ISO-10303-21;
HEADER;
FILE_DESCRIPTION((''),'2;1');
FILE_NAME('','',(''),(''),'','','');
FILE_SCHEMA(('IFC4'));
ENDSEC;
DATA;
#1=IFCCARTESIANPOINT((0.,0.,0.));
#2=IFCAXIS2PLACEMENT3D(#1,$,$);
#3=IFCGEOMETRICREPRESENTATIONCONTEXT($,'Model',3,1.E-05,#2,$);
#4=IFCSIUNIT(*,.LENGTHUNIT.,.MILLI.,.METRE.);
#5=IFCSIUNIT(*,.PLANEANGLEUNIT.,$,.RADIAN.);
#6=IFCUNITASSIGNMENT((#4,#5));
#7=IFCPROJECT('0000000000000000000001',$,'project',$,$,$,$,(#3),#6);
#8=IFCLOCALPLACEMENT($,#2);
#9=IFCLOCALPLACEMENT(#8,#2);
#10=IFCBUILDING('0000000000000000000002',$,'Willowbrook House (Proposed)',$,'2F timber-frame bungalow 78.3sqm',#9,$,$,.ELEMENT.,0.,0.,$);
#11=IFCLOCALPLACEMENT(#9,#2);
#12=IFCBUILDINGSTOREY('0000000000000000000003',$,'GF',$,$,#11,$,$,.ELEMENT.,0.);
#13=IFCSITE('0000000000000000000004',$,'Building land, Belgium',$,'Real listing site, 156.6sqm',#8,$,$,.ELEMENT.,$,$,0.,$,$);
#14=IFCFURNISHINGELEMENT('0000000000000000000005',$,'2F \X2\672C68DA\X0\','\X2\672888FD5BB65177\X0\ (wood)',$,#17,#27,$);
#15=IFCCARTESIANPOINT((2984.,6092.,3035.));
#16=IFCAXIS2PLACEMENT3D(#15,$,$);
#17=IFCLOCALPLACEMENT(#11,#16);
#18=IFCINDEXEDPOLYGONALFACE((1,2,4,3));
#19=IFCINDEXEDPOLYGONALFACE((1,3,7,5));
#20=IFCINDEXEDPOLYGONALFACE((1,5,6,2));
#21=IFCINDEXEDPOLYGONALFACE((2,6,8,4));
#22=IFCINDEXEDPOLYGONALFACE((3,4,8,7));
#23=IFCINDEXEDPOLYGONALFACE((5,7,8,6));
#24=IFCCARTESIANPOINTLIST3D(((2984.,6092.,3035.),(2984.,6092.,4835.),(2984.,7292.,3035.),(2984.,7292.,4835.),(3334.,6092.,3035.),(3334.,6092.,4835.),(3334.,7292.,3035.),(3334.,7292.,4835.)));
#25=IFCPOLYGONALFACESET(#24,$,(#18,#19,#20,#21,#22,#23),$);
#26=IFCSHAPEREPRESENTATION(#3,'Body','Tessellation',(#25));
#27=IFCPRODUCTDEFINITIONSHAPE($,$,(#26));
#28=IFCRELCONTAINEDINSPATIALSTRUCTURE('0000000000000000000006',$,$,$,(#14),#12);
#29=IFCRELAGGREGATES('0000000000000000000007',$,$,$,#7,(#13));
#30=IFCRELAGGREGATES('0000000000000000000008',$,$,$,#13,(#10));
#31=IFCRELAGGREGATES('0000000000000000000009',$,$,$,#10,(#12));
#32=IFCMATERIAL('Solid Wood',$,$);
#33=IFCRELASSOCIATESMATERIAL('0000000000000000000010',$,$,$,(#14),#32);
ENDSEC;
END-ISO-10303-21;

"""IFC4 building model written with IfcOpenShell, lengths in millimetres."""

from ifc_helpers import new_model, si_unit, frame, frame_2d, origin, place, context, project, spatial, rectangle, extrude, material, element, save


model = new_model("IFC4")

# Units and contexts
model_context = context("Model", 3, precision=1e-05, world=origin())
ifc_project = project(units=[si_unit("LENGTHUNIT", "METRE", prefix="MILLI"), si_unit("PLANEANGLEUNIT", "RADIAN")], contexts=[model_context])

# Site, building, storey
site_placement = place(None, origin())
site = spatial("IfcSite", under=ifc_project, at=site_placement, Name="Building land, Belgium", ObjectType="Real listing site, 156.6sqm", CompositionType="ELEMENT", RefElevation=0.0)
building_placement = place(site_placement, origin())
building = spatial("IfcBuilding", under=site, at=building_placement, Name="Willowbrook House (Proposed)", ObjectType="2F timber-frame bungalow 78.3sqm", CompositionType="ELEMENT", ElevationOfRefHeight=0.0, ElevationOfTerrain=0.0)
storey_placement = place(building_placement, origin())
storey = spatial("IfcBuildingStorey", under=building, at=storey_placement, Name="GF", CompositionType="ELEMENT", Elevation=0.0)

# Shared definitions
ifc_material_1 = material(Name="Solid Wood")

# Furnishing element
furnishing_1_placement = place(storey_placement, frame((2984.0, 6092.0, 3035.0)))
element("IfcFurnishingElement", 1, at=furnishing_1_placement, inside=storey, material=ifc_material_1, Name="2F 本棚", Description="木製家具 (wood)", context=model_context, shape_type="SweptSolid", body=[
    extrude(rectangle(XDim=350.0, YDim=1200.0, at=frame_2d((175.0, 600.0))), frame((2984.0, 6092.0, 3035.0)), (0.0, 0.0, 1.0), 1800.0),
])

save(model, "model.ifc")
